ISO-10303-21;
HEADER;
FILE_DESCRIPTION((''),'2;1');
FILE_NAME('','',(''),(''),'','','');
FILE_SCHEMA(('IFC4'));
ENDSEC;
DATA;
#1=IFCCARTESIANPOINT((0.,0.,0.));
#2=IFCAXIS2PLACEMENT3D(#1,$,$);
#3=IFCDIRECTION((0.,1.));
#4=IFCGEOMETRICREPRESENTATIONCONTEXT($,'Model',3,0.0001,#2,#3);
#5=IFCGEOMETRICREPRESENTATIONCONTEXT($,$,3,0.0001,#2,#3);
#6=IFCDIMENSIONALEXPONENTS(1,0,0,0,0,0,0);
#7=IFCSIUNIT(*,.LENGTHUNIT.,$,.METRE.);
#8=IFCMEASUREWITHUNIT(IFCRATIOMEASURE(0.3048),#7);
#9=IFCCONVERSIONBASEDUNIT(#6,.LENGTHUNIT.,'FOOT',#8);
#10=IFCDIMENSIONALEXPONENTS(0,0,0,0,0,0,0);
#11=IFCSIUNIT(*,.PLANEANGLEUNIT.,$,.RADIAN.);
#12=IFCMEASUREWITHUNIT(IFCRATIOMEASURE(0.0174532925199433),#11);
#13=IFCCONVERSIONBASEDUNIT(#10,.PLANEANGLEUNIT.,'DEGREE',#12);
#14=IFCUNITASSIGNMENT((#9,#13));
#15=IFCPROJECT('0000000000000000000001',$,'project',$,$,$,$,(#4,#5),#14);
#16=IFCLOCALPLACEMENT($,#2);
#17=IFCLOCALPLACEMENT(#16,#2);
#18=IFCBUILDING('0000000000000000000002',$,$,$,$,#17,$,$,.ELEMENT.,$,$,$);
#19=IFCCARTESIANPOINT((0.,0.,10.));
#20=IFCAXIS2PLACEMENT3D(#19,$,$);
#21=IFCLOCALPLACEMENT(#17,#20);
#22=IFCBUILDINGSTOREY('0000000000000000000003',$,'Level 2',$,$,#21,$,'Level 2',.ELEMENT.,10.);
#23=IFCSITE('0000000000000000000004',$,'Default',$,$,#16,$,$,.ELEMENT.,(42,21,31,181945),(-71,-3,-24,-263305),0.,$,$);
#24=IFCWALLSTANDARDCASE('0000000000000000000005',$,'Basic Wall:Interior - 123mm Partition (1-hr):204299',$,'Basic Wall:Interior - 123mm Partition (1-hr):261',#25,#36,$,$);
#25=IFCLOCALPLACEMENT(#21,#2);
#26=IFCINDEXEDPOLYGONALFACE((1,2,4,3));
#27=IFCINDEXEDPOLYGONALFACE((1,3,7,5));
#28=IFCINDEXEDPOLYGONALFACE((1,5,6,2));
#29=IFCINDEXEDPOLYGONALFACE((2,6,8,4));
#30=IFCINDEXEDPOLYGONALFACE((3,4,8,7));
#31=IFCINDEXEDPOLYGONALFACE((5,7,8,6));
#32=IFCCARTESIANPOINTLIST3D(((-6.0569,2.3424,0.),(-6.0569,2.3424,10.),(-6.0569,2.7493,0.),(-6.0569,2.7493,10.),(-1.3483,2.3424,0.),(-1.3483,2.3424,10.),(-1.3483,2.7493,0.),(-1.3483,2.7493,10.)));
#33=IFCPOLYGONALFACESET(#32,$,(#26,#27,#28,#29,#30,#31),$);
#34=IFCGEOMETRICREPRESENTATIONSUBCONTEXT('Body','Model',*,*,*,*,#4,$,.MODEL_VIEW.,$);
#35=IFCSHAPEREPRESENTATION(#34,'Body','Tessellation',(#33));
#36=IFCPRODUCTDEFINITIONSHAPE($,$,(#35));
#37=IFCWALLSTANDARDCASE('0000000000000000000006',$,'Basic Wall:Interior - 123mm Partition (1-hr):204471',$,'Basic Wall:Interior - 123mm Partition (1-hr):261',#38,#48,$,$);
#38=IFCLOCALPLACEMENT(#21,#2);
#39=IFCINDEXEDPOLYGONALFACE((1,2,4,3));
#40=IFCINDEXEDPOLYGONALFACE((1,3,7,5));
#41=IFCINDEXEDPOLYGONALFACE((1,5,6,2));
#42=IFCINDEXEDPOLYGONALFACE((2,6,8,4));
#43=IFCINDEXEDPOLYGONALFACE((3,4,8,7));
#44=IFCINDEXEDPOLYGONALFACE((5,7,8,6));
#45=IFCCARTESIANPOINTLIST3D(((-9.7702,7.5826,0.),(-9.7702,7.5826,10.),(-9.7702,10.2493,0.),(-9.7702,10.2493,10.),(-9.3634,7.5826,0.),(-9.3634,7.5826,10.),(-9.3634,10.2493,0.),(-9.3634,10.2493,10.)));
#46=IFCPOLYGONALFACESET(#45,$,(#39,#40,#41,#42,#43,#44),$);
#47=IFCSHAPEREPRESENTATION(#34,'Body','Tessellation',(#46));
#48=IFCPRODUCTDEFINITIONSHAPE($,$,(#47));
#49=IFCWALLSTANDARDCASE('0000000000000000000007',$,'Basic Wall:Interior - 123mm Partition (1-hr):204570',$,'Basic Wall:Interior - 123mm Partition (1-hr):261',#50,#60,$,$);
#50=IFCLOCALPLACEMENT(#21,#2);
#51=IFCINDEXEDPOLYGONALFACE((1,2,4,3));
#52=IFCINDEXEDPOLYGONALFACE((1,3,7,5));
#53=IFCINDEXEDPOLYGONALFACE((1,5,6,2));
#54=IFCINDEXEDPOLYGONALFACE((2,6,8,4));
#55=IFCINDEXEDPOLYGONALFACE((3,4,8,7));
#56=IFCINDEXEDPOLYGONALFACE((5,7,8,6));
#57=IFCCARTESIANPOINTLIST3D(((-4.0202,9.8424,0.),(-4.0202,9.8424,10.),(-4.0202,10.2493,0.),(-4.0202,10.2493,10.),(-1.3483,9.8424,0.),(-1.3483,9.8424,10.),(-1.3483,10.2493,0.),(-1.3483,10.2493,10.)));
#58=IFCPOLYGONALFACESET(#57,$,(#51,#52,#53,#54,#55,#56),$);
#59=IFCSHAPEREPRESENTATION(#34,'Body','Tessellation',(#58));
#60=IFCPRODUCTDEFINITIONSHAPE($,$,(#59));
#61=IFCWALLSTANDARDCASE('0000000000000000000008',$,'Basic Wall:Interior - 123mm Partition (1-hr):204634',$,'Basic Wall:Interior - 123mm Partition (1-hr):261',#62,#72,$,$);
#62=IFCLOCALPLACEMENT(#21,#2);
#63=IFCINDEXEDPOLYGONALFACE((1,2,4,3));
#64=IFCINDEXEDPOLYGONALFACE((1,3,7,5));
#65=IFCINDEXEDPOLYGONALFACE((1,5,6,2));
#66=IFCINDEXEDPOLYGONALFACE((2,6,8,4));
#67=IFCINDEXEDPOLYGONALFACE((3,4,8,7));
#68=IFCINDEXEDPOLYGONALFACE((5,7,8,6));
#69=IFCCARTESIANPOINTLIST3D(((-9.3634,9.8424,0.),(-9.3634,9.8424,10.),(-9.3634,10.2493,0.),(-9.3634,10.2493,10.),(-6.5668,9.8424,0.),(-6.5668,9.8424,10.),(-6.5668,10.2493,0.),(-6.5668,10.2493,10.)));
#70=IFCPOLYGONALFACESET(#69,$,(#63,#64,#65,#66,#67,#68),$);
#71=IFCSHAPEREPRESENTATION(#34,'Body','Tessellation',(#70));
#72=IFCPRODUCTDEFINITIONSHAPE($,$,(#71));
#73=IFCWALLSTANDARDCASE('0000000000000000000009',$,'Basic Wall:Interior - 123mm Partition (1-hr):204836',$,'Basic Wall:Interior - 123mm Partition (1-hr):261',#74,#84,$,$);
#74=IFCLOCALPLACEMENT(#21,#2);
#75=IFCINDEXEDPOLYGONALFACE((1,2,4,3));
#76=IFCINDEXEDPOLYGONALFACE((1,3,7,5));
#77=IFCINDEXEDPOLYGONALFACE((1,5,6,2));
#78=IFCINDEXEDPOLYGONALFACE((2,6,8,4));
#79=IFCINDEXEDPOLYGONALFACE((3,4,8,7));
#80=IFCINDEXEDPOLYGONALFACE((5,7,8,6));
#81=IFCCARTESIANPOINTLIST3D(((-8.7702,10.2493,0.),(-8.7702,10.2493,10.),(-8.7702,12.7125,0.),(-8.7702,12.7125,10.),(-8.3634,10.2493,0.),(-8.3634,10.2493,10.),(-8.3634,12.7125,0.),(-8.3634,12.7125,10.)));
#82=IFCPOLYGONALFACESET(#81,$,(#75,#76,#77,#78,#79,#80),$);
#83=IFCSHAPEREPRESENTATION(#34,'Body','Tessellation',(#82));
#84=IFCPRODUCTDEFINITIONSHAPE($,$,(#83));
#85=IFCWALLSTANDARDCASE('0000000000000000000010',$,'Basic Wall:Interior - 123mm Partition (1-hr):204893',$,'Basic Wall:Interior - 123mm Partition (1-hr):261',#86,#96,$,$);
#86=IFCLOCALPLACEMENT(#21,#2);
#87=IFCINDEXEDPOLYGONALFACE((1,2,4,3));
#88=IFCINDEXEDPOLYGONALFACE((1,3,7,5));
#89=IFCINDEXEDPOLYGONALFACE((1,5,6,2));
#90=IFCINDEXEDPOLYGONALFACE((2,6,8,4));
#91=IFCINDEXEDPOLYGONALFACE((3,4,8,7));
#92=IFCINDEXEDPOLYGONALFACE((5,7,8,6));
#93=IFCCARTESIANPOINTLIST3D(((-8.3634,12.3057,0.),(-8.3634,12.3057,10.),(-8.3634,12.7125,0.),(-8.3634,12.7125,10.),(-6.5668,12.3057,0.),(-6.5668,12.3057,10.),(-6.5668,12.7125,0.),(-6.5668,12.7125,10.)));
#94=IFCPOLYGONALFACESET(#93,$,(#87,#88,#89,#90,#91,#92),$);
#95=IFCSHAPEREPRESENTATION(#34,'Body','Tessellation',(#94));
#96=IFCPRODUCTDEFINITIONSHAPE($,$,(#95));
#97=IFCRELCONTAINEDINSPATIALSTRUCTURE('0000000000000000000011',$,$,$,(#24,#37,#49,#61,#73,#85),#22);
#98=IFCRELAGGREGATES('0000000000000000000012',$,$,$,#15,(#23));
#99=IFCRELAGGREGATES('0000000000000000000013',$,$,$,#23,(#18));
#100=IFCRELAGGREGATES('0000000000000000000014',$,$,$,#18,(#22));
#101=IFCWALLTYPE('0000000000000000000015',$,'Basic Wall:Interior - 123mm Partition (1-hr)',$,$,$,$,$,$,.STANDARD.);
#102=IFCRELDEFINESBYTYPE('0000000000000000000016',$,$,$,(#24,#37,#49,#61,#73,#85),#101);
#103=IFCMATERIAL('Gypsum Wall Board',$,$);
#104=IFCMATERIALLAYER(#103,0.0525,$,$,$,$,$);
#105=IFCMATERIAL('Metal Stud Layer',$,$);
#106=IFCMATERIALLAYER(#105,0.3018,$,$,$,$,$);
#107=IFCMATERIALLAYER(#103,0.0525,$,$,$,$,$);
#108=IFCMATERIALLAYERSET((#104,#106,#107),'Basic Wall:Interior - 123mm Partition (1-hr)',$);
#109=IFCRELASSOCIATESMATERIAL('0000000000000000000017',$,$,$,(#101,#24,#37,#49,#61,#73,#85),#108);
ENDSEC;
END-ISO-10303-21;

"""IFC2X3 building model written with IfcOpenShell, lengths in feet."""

from ifc_helpers import new_model, entity, si_unit, converted_unit, direction, frame, frame_2d, origin, place, context, subcontext, project, spatial, rectangle, extrude, material, layer, layer_set, layer_usage, type_object, element, save


model = new_model("IFC2X3")

# Units and contexts
model_context = context("Model", 3, precision=0.0001, world=origin(), true_north=direction((0.0, 1.0)))
context_of_model = context(None, 3, precision=0.0001, world=origin(), true_north=direction((0.0, 1.0)))
body_context = subcontext(model_context, "Body", "Model", "MODEL_VIEW")
ifc_project = project(units=[converted_unit("LENGTHUNIT", "FOOT", entity("IfcRatioMeasure", 0.3048), si_unit("LENGTHUNIT", "METRE"), dimensions=[1, 0, 0, 0, 0, 0, 0]), converted_unit("PLANEANGLEUNIT", "DEGREE", entity("IfcRatioMeasure", 0.0174532925199433), si_unit("PLANEANGLEUNIT", "RADIAN"), dimensions=[0, 0, 0, 0, 0, 0, 0])], contexts=[model_context, context_of_model])

# Site, building, storey
site_placement = place(None, origin())
site = spatial("IfcSite", under=ifc_project, at=site_placement, Name="Default", CompositionType="ELEMENT", RefLatitude=(42, 21, 31, 181945), RefLongitude=(-71, -3, -24, -263305), RefElevation=0.0)
building_placement = place(site_placement, origin())
building = spatial("IfcBuilding", under=site, at=building_placement, CompositionType="ELEMENT")
storey_placement = place(building_placement, frame((0.0, 0.0, 10.0)))
storey = spatial("IfcBuildingStorey", under=building, at=storey_placement, Name="Level 2", LongName="Level 2", CompositionType="ELEMENT", Elevation=10.0)

# Wall
ifc_material_1 = material(Name="Gypsum Wall Board")
ifc_layer_1 = layer(ifc_material_1, 0.0525)
ifc_material_2 = material(Name="Metal Stud Layer")
ifc_layer_2 = layer(ifc_material_2, 0.3018)
ifc_layer_3 = layer(ifc_material_1, 0.0525)
ifc_layer_set_1 = layer_set([ifc_layer_1, ifc_layer_2, ifc_layer_3], Name="Basic Wall:Interior - 123mm Partition (1-hr)")
wall_type_1 = type_object("IfcWallType", Name="Basic Wall:Interior - 123mm Partition (1-hr)", PredefinedType="STANDARD", material=ifc_layer_set_1)
ifc_layer_usage_1 = layer_usage(ifc_layer_set_1, "AXIS2", "NEGATIVE", 0.2034)
wall_1_placement = place(storey_placement, frame((-1.3483, 2.5459, 0.0), z_axis=(0.0, 0.0, 1.0), x_axis=(-1.0, 0.0, 0.0)))
element("IfcWallStandardCase", 1, at=wall_1_placement, inside=storey, type_object=wall_type_1, material=ifc_layer_usage_1, Name="Basic Wall:Interior - 123mm Partition (1-hr):204299", ObjectType="Basic Wall:Interior - 123mm Partition (1-hr):261", context=body_context, shape_type="SweptSolid", body=[
    extrude(rectangle(XDim=4.7087, YDim=0.4068, at=frame_2d((2.3543, 0.0), x_axis=(-1.0, 0.0))), origin(), (0.0, 0.0, 1.0), 10.0),
])

# Walls
ifc_layer_usage_2 = layer_usage(ifc_layer_set_1, "AXIS2", "NEGATIVE", 0.2034)
wall_2_placement = place(storey_placement, frame((-9.5668, 7.5826, 0.0), z_axis=(0.0, 0.0, 1.0), x_axis=(0.0, 1.0, 0.0)))
element("IfcWallStandardCase", 2, at=wall_2_placement, inside=storey, type_object=wall_type_1, material=ifc_layer_usage_2, Name="Basic Wall:Interior - 123mm Partition (1-hr):204471", ObjectType="Basic Wall:Interior - 123mm Partition (1-hr):261", context=body_context, shape_type="SweptSolid", body=[
    extrude(rectangle(XDim=2.6667, YDim=0.4068, at=frame_2d((1.3333, 0.0), x_axis=(-1.0, 0.0))), origin(), (0.0, 0.0, 1.0), 10.0),
])
ifc_layer_usage_3 = layer_usage(ifc_layer_set_1, "AXIS2", "NEGATIVE", 0.2034)
wall_3_placement = place(storey_placement, frame((-1.3483, 10.0459, 0.0), z_axis=(0.0, 0.0, 1.0), x_axis=(-1.0, 0.0, 0.0)))
element("IfcWallStandardCase", 3, at=wall_3_placement, inside=storey, type_object=wall_type_1, material=ifc_layer_usage_3, Name="Basic Wall:Interior - 123mm Partition (1-hr):204570", ObjectType="Basic Wall:Interior - 123mm Partition (1-hr):261", context=body_context, shape_type="SweptSolid", body=[
    extrude(rectangle(XDim=2.6719, YDim=0.4068, at=frame_2d((1.336, 0.0), x_axis=(-1.0, 0.0))), origin(), (0.0, 0.0, 1.0), 10.0),
])
ifc_layer_usage_4 = layer_usage(ifc_layer_set_1, "AXIS2", "NEGATIVE", 0.2034)
wall_4_placement = place(storey_placement, frame((-6.5668, 10.0459, 0.0), z_axis=(0.0, 0.0, 1.0), x_axis=(-1.0, 0.0, 0.0)))
element("IfcWallStandardCase", 4, at=wall_4_placement, inside=storey, type_object=wall_type_1, material=ifc_layer_usage_4, Name="Basic Wall:Interior - 123mm Partition (1-hr):204634", ObjectType="Basic Wall:Interior - 123mm Partition (1-hr):261", context=body_context, shape_type="SweptSolid", body=[
    extrude(rectangle(XDim=2.7966, YDim=0.4068, at=frame_2d((1.3983, 0.0), x_axis=(-1.0, 0.0))), origin(), (0.0, 0.0, 1.0), 10.0),
])
ifc_layer_usage_5 = layer_usage(ifc_layer_set_1, "AXIS2", "NEGATIVE", 0.2034)
wall_5_placement = place(storey_placement, frame((-8.5668, 10.2493, 0.0), z_axis=(0.0, 0.0, 1.0), x_axis=(0.0, 1.0, 0.0)))
element("IfcWallStandardCase", 5, at=wall_5_placement, inside=storey, type_object=wall_type_1, material=ifc_layer_usage_5, Name="Basic Wall:Interior - 123mm Partition (1-hr):204836", ObjectType="Basic Wall:Interior - 123mm Partition (1-hr):261", context=body_context, shape_type="SweptSolid", body=[
    extrude(rectangle(XDim=2.4633, YDim=0.4068, at=frame_2d((1.2316, 0.0), x_axis=(-1.0, 0.0))), origin(), (0.0, 0.0, 1.0), 10.0),
])
ifc_layer_usage_6 = layer_usage(ifc_layer_set_1, "AXIS2", "NEGATIVE", 0.2034)
wall_6_placement = place(storey_placement, frame((-6.5668, 12.5091, 0.0), z_axis=(0.0, 0.0, 1.0), x_axis=(-1.0, 0.0, 0.0)))
element("IfcWallStandardCase", 6, at=wall_6_placement, inside=storey, type_object=wall_type_1, material=ifc_layer_usage_6, Name="Basic Wall:Interior - 123mm Partition (1-hr):204893", ObjectType="Basic Wall:Interior - 123mm Partition (1-hr):261", context=body_context, shape_type="SweptSolid", body=[
    extrude(rectangle(XDim=1.7966, YDim=0.4068, at=frame_2d((0.8983, 0.0), x_axis=(-1.0, 0.0))), origin(), (0.0, 0.0, 1.0), 10.0),
])

save(model, "model.ifc")
